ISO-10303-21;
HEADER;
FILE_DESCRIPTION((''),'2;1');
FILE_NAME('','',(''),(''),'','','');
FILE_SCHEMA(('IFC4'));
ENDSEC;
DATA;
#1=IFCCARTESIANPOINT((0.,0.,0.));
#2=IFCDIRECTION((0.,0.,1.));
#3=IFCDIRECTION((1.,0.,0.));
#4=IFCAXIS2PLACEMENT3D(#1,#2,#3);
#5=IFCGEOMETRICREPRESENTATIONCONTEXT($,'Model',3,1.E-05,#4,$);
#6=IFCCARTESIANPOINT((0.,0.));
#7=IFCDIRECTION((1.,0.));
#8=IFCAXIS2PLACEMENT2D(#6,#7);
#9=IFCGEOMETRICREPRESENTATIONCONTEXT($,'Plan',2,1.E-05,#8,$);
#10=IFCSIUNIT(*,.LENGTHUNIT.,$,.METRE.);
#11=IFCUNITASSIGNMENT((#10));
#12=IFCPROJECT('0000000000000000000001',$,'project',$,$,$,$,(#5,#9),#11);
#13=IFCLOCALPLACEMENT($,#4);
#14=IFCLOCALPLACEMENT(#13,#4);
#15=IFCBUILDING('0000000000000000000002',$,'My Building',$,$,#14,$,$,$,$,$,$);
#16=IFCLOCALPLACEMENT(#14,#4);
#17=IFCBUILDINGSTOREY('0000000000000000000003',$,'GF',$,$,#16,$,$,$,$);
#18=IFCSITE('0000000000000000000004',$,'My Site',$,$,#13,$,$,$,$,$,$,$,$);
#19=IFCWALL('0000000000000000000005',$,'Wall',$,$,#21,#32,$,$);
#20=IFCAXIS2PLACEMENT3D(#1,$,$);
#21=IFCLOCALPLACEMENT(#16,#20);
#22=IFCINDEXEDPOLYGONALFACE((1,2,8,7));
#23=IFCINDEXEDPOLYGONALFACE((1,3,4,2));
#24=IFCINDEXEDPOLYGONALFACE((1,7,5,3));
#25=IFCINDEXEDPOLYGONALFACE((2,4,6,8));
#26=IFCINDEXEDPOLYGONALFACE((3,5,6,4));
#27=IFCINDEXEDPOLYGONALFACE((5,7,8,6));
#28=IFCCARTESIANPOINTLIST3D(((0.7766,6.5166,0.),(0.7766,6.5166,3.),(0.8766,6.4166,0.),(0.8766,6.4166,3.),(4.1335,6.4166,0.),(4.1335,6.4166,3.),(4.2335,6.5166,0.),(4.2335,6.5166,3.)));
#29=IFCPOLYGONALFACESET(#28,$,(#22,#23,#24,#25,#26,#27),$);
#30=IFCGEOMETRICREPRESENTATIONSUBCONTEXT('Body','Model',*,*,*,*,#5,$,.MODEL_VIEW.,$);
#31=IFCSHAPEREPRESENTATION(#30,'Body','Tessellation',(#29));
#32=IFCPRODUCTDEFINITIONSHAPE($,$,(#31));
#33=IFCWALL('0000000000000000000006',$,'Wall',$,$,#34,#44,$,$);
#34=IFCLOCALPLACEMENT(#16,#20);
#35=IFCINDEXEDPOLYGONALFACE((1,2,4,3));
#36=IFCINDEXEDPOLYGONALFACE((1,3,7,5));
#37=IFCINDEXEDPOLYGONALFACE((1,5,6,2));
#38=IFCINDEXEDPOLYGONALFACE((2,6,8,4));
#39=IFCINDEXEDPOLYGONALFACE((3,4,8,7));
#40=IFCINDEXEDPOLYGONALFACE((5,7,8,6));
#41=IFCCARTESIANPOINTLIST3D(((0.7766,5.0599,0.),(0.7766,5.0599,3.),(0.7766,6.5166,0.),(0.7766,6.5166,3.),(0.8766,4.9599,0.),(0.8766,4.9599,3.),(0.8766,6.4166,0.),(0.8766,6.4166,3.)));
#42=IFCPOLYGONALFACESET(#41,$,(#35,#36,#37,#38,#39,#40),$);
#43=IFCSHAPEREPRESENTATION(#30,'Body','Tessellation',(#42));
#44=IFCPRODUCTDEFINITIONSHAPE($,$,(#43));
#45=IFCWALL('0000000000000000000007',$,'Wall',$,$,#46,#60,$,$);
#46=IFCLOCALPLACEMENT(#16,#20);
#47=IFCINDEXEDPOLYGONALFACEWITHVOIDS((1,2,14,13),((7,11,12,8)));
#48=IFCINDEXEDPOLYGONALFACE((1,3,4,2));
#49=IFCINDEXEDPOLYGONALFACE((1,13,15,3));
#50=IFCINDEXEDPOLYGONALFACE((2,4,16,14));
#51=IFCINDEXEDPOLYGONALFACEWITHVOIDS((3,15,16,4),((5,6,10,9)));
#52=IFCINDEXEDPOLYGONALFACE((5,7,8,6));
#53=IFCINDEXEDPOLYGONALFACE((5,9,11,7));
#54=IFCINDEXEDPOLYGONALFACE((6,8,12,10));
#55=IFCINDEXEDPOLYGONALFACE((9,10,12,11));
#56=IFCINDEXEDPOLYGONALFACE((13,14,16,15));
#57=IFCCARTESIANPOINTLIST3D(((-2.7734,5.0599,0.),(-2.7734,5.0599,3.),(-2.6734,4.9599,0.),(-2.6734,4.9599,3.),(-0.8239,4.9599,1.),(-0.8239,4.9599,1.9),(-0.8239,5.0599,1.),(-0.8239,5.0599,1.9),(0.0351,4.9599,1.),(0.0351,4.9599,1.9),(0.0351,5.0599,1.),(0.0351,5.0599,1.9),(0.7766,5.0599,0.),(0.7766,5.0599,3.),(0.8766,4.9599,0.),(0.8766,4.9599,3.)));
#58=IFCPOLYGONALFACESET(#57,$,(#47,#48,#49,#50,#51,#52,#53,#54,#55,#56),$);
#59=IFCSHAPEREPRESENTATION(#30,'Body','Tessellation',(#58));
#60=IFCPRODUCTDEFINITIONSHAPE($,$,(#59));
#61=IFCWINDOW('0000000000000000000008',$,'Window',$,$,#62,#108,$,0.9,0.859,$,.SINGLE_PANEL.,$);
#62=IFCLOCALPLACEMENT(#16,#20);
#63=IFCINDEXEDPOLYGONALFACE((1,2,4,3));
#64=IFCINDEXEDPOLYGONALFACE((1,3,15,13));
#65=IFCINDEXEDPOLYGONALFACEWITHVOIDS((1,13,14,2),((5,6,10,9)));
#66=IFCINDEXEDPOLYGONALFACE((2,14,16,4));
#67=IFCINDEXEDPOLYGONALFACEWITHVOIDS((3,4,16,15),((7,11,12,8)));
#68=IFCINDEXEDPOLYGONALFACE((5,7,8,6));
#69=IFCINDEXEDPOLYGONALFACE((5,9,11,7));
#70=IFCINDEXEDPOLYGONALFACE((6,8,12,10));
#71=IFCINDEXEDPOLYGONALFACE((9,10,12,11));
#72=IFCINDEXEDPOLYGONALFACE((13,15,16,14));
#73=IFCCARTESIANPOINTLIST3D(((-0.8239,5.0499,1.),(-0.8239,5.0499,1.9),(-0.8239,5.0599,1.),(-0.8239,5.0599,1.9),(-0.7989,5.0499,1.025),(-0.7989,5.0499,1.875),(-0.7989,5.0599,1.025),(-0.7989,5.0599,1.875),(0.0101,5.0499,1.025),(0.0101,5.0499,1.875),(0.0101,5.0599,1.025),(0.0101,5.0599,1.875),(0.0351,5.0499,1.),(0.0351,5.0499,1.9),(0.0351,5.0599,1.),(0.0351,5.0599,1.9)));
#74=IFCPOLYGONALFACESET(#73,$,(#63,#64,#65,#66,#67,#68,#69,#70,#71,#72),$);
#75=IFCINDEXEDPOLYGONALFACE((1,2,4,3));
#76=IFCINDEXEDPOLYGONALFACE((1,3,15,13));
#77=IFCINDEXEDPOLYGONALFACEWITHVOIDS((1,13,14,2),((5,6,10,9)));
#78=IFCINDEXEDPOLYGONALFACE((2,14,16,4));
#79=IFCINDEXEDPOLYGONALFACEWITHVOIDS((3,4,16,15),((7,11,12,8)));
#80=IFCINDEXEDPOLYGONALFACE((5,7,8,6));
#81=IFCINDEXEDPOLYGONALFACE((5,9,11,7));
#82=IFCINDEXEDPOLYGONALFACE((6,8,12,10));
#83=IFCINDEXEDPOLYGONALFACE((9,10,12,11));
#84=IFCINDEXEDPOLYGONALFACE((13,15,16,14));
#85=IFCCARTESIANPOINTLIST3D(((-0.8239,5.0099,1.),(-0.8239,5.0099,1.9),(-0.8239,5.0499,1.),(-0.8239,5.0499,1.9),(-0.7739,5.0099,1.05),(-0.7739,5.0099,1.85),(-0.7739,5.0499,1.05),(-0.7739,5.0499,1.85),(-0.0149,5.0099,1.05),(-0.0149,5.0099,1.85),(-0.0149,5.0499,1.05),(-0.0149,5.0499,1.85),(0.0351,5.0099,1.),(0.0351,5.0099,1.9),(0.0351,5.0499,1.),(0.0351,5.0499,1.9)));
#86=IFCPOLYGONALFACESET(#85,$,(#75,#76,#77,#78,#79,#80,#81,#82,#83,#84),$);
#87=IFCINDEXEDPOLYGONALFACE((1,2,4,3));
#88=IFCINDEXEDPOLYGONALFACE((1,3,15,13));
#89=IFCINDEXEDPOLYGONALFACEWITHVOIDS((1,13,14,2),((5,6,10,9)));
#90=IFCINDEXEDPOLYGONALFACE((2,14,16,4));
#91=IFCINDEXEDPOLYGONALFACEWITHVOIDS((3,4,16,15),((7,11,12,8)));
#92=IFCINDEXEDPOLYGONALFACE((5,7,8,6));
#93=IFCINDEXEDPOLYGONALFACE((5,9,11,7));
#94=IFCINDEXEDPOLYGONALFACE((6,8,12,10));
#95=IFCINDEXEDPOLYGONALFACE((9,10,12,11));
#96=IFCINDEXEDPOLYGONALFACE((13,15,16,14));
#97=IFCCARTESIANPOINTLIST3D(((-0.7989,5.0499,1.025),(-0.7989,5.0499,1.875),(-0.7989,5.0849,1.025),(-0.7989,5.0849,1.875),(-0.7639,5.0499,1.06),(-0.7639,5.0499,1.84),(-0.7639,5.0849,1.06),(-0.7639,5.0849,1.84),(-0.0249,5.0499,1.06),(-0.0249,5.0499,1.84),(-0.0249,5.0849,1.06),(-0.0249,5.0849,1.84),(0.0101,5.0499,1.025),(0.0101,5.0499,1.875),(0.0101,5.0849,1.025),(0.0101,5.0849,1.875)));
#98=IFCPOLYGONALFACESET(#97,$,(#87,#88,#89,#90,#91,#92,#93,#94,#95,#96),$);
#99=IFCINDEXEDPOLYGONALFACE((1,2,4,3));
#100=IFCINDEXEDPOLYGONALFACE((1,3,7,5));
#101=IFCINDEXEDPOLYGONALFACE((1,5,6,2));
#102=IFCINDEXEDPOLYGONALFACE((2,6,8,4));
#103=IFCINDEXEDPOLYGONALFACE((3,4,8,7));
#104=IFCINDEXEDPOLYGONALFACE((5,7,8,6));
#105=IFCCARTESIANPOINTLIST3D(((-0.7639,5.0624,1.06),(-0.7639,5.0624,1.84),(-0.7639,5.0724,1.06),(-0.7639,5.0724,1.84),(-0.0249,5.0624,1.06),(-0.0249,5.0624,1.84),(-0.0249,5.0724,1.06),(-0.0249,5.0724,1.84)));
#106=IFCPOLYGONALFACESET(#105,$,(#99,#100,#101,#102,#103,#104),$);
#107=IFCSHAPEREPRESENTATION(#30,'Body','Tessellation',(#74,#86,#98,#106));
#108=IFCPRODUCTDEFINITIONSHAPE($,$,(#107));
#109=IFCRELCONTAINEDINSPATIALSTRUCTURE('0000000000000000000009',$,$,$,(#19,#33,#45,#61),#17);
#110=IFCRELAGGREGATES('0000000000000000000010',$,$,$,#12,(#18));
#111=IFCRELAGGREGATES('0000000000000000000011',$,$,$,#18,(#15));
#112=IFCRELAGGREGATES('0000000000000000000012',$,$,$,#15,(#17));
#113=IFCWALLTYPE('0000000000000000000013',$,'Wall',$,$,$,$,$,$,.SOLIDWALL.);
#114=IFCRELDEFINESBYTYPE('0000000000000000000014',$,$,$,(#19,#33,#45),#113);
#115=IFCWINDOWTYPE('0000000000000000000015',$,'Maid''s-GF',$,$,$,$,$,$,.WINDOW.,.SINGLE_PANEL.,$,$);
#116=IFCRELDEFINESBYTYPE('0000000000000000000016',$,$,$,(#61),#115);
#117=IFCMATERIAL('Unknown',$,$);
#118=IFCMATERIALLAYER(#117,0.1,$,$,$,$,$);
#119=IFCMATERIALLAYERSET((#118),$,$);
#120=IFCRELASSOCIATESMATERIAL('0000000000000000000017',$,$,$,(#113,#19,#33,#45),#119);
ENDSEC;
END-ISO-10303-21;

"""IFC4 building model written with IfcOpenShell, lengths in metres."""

from ifc_helpers import new_model, entity, si_unit, frame, origin_with_axes, origin_2d_with_axis, place, context, subcontext, project, spatial, line, indexed_curve, outline, extrude, shape, source, transform, mapped, material, layer, layer_set, layer_usage, type_object, type_shapes, element, fill, save


model = new_model("IFC4")

# Units and contexts
model_context = context("Model", 3, precision=1e-05, world=origin_with_axes())
plan_context = context("Plan", 2, precision=1e-05, world=origin_2d_with_axis())
body_context_1 = subcontext(model_context, "Body", "Model", "MODEL_VIEW")
body_context_2 = subcontext(plan_context, "Body", "Plan", "PLAN_VIEW")
ifc_project = project(units=[si_unit("LENGTHUNIT", "METRE")], contexts=[model_context, plan_context])

# Site, building, storey
site_placement = place(None, origin_with_axes())
site = spatial("IfcSite", under=ifc_project, at=site_placement, Name="My Site")
building_placement = place(site_placement, origin_with_axes())
building = spatial("IfcBuilding", under=site, at=building_placement, Name="My Building")
storey_placement = place(building_placement, origin_with_axes())
storey = spatial("IfcBuildingStorey", under=building, at=storey_placement, Name="GF")

# Walls
ifc_material = material(Name="Unknown")
ifc_layer = layer(ifc_material, 0.1)
ifc_layer_set = layer_set([ifc_layer])
ifc_layer_usage_1 = layer_usage(ifc_layer_set, "AXIS2", "POSITIVE", 0.0)
wall_type = type_object("IfcWallType", Name="Wall", PredefinedType="SOLIDWALL", material=ifc_layer_set)
wall_1_placement = place(storey_placement, frame((4.2335, 6.5166, 0.0), z_axis=(0.0, 0.0, 1.0), x_axis=(-1.0, 0.0, 0.0)))
element("IfcWall", 1, at=wall_1_placement, inside=storey, type_object=wall_type, material=ifc_layer_usage_1, Name="Wall", context=body_context_1, shape_type="SweptSolid", body=[
    extrude(outline(indexed_curve([(0.0, 0.0), (0.1, 0.1), (3.3569, 0.1), (3.4569, 0.0)], segments=[line(1, 2, 3, 4, 1)])), origin_with_axes(), (0.0, 0.0, 1.0), 3.0),
])
ifc_layer_usage_2 = layer_usage(ifc_layer_set, "AXIS2", "POSITIVE", 0.0)
wall_2_placement = place(storey_placement, frame((0.7766, 6.5166, 0.0), z_axis=(0.0, 0.0, 1.0), x_axis=(0.0, -1.0, 0.0)))
element("IfcWall", 2, at=wall_2_placement, inside=storey, type_object=wall_type, material=ifc_layer_usage_2, Name="Wall", context=body_context_1, shape_type="SweptSolid", body=[
    extrude(outline(indexed_curve([(0.0, 0.0), (0.1, 0.1), (1.5567, 0.1), (1.4567, 0.0)], segments=[line(1, 2, 3, 4, 1)])), origin_with_axes(), (0.0, 0.0, 1.0), 3.0),
])

# Wall, opening, window
ifc_layer_usage_3 = layer_usage(ifc_layer_set, "AXIS2", "POSITIVE", 0.0)
wall_3_placement = place(storey_placement, frame((0.7766, 5.0599, 0.0), z_axis=(0.0, 0.0, 1.0), x_axis=(-1.0, 0.0, 0.0)))
wall_3 = element("IfcWall", 3, at=wall_3_placement, inside=storey, type_object=wall_type, material=ifc_layer_usage_3, Name="Wall", context=body_context_1, shape_type="SweptSolid", body=[
    extrude(outline(indexed_curve([(0.0, 0.0), (-0.1, 0.1), (3.45, 0.1), (3.55, 0.0)], segments=[line(1, 2, 3, 4, 1)])), origin_with_axes(), (0.0, 0.0, 1.0), 3.0),
])
shared_shape_1 = source(origin_with_axes(), body_context_1, "Body", "SweptSolid", [
    extrude(outline(indexed_curve([(0.0, 0.0), (0.859, 0.0), (0.859, 0.9), (0.0, 0.9)], segments=[line(1, 2, 3, 4, 1)])), frame((0.0, -0.6, 0.0), z_axis=(0.0, -1.0, 0.0), x_axis=(1.0, 0.0, 0.0)), (0.0, 0.0, -1.0), 1.2),
])
opening_1_placement = place(wall_3_placement, frame((1.6005, 0.1, 1.0), z_axis=(0.0, 0.0, 1.0), x_axis=(-1.0, 0.000001, 0.0)))
opening_1 = element("IfcOpeningElement", 4, at=opening_1_placement, cuts=wall_3, PredefinedType="OPENING", context=body_context_1, shape_type="MappedRepresentation", body=[
    mapped(shared_shape_1, transform((0.0, 0.0, 0.0), x_axis=(1.0, 0.0, 0.0), y_axis=(0.0, 1.0, 0.0), z_axis=(0.0, 0.0, 1.0), scale=1.0)),
])
window_type_1 = type_object("IfcWindowType", Name="Maid's-GF", PartitioningType="SINGLE_PANEL", PredefinedType="WINDOW")
shared_shape_2 = source(origin_with_axes(), body_context_1, "Body", "SweptSolid", [
    extrude(outline(indexed_curve([(0.0, 0.0), (0.859, 0.0), (0.859, 0.9), (0.0, 0.9)], segments=[line(1, 2, 3, 4, 1)]), holes=[indexed_curve([(0.025, 0.025), (0.834, 0.025), (0.834, 0.875), (0.025, 0.875)], segments=[line(1, 2, 3, 4, 1)])]), frame((0.0, 0.09, 0.0), z_axis=(0.0, -1.0, 0.0), x_axis=(1.0, 0.0, 0.0)), (0.0, 0.0, -1.0), 0.01),
    extrude(outline(indexed_curve([(0.0, 0.0), (0.859, 0.0), (0.859, 0.9), (0.0, 0.9)], segments=[line(1, 2, 3, 4, 1)]), holes=[indexed_curve([(0.05, 0.05), (0.809, 0.05), (0.809, 0.85), (0.05, 0.85)], segments=[line(1, 2, 3, 4, 1)])]), frame((0.0, 0.05, 0.0), z_axis=(0.0, -1.0, 0.0), x_axis=(1.0, 0.0, 0.0)), (0.0, 0.0, -1.0), 0.04),
    extrude(outline(indexed_curve([(0.0, 0.0), (0.809, 0.0), (0.809, 0.85), (0.0, 0.85)], segments=[line(1, 2, 3, 4, 1)]), holes=[indexed_curve([(0.035, 0.035), (0.774, 0.035), (0.774, 0.815), (0.035, 0.815)], segments=[line(1, 2, 3, 4, 1)])]), frame((0.025, 0.09, 0.025), z_axis=(0.0, -1.0, 0.0), x_axis=(1.0, 0.0, 0.0)), (0.0, 0.0, -1.0), 0.035),
    extrude(outline(indexed_curve([(0.035, 0.035), (0.774, 0.035), (0.774, 0.815), (0.035, 0.815)], segments=[line(1, 2, 3, 4, 1)])), frame((0.025, 0.1025, 0.025), z_axis=(0.0, -1.0, 0.0), x_axis=(1.0, 0.0, 0.0)), (0.0, 0.0, -1.0), 0.01),
])
shared_shape_3 = source(origin_with_axes(), body_context_2, "Body", "Curve2D", [
    entity("IfcIndexedPolyCurve", entity("IfcCartesianPointList2D", [[0.05, 0.05], [0.809, 0.05]])),
    entity("IfcIndexedPolyCurve", entity("IfcCartesianPointList2D", [[0.0, 0.1], [0.025, 0.1], [0.025, 0.09], [0.05, 0.09], [0.05, 0.05], [0.0, 0.05]]), [entity("IfcLineIndex", [1, 2, 3, 4, 5, 6, 1])]),
    entity("IfcIndexedPolyCurve", entity("IfcCartesianPointList2D", [[0.859, 0.1], [0.834, 0.1], [0.834, 0.09], [0.809, 0.09], [0.809, 0.05], [0.859, 0.05]]), [entity("IfcLineIndex", [1, 2, 3, 4, 5, 6, 1])]),
    entity("IfcIndexedPolyCurve", entity("IfcCartesianPointList2D", [[0.025, 0.09], [0.06, 0.09], [0.06, 0.125], [0.025, 0.125]]), [entity("IfcLineIndex", [1, 2, 3, 4, 1])]),
    entity("IfcIndexedPolyCurve", entity("IfcCartesianPointList2D", [[0.834, 0.09], [0.799, 0.09], [0.799, 0.125], [0.834, 0.125]]), [entity("IfcLineIndex", [1, 2, 3, 4, 1])]),
    entity("IfcIndexedPolyCurve", entity("IfcCartesianPointList2D", [[0.06, 0.09], [0.799, 0.09]])),
    entity("IfcIndexedPolyCurve", entity("IfcCartesianPointList2D", [[0.06, 0.125], [0.799, 0.125]])),
    entity("IfcIndexedPolyCurve", entity("IfcCartesianPointList2D", [[0.06, 0.1075], [0.799, 0.1075]])),
])
type_shapes(window_type_1, [shared_shape_2, shared_shape_3])
window_1_placement = place(opening_1_placement, frame((0.0, 0.0, 0.0), z_axis=(0.0, 0.0, 1.0), x_axis=(1.0, 0.0, 0.0)))
window_1 = element("IfcWindow", 5, at=window_1_placement, inside=storey, type_object=window_type_1, Name="Window", OverallHeight=0.9, OverallWidth=0.859, PartitioningType="SINGLE_PANEL", shapes=[
    shape(body_context_1, "Body", "MappedRepresentation", [mapped(shared_shape_2, transform((0.0, 0.0, 0.0), x_axis=(1.0, 0.0, 0.0), y_axis=(0.0, 1.0, 0.0), z_axis=(0.0, 0.0, 1.0), scale=1.0))]),
    shape(body_context_2, "Body", "MappedRepresentation", [mapped(shared_shape_3, transform((0.0, 0.0, 0.0), x_axis=(1.0, 0.0, 0.0), y_axis=(0.0, 1.0, 0.0), z_axis=(0.0, 0.0, 1.0), scale=1.0))]),
])
fill(opening_1, window_1)

save(model, "model.ifc")
